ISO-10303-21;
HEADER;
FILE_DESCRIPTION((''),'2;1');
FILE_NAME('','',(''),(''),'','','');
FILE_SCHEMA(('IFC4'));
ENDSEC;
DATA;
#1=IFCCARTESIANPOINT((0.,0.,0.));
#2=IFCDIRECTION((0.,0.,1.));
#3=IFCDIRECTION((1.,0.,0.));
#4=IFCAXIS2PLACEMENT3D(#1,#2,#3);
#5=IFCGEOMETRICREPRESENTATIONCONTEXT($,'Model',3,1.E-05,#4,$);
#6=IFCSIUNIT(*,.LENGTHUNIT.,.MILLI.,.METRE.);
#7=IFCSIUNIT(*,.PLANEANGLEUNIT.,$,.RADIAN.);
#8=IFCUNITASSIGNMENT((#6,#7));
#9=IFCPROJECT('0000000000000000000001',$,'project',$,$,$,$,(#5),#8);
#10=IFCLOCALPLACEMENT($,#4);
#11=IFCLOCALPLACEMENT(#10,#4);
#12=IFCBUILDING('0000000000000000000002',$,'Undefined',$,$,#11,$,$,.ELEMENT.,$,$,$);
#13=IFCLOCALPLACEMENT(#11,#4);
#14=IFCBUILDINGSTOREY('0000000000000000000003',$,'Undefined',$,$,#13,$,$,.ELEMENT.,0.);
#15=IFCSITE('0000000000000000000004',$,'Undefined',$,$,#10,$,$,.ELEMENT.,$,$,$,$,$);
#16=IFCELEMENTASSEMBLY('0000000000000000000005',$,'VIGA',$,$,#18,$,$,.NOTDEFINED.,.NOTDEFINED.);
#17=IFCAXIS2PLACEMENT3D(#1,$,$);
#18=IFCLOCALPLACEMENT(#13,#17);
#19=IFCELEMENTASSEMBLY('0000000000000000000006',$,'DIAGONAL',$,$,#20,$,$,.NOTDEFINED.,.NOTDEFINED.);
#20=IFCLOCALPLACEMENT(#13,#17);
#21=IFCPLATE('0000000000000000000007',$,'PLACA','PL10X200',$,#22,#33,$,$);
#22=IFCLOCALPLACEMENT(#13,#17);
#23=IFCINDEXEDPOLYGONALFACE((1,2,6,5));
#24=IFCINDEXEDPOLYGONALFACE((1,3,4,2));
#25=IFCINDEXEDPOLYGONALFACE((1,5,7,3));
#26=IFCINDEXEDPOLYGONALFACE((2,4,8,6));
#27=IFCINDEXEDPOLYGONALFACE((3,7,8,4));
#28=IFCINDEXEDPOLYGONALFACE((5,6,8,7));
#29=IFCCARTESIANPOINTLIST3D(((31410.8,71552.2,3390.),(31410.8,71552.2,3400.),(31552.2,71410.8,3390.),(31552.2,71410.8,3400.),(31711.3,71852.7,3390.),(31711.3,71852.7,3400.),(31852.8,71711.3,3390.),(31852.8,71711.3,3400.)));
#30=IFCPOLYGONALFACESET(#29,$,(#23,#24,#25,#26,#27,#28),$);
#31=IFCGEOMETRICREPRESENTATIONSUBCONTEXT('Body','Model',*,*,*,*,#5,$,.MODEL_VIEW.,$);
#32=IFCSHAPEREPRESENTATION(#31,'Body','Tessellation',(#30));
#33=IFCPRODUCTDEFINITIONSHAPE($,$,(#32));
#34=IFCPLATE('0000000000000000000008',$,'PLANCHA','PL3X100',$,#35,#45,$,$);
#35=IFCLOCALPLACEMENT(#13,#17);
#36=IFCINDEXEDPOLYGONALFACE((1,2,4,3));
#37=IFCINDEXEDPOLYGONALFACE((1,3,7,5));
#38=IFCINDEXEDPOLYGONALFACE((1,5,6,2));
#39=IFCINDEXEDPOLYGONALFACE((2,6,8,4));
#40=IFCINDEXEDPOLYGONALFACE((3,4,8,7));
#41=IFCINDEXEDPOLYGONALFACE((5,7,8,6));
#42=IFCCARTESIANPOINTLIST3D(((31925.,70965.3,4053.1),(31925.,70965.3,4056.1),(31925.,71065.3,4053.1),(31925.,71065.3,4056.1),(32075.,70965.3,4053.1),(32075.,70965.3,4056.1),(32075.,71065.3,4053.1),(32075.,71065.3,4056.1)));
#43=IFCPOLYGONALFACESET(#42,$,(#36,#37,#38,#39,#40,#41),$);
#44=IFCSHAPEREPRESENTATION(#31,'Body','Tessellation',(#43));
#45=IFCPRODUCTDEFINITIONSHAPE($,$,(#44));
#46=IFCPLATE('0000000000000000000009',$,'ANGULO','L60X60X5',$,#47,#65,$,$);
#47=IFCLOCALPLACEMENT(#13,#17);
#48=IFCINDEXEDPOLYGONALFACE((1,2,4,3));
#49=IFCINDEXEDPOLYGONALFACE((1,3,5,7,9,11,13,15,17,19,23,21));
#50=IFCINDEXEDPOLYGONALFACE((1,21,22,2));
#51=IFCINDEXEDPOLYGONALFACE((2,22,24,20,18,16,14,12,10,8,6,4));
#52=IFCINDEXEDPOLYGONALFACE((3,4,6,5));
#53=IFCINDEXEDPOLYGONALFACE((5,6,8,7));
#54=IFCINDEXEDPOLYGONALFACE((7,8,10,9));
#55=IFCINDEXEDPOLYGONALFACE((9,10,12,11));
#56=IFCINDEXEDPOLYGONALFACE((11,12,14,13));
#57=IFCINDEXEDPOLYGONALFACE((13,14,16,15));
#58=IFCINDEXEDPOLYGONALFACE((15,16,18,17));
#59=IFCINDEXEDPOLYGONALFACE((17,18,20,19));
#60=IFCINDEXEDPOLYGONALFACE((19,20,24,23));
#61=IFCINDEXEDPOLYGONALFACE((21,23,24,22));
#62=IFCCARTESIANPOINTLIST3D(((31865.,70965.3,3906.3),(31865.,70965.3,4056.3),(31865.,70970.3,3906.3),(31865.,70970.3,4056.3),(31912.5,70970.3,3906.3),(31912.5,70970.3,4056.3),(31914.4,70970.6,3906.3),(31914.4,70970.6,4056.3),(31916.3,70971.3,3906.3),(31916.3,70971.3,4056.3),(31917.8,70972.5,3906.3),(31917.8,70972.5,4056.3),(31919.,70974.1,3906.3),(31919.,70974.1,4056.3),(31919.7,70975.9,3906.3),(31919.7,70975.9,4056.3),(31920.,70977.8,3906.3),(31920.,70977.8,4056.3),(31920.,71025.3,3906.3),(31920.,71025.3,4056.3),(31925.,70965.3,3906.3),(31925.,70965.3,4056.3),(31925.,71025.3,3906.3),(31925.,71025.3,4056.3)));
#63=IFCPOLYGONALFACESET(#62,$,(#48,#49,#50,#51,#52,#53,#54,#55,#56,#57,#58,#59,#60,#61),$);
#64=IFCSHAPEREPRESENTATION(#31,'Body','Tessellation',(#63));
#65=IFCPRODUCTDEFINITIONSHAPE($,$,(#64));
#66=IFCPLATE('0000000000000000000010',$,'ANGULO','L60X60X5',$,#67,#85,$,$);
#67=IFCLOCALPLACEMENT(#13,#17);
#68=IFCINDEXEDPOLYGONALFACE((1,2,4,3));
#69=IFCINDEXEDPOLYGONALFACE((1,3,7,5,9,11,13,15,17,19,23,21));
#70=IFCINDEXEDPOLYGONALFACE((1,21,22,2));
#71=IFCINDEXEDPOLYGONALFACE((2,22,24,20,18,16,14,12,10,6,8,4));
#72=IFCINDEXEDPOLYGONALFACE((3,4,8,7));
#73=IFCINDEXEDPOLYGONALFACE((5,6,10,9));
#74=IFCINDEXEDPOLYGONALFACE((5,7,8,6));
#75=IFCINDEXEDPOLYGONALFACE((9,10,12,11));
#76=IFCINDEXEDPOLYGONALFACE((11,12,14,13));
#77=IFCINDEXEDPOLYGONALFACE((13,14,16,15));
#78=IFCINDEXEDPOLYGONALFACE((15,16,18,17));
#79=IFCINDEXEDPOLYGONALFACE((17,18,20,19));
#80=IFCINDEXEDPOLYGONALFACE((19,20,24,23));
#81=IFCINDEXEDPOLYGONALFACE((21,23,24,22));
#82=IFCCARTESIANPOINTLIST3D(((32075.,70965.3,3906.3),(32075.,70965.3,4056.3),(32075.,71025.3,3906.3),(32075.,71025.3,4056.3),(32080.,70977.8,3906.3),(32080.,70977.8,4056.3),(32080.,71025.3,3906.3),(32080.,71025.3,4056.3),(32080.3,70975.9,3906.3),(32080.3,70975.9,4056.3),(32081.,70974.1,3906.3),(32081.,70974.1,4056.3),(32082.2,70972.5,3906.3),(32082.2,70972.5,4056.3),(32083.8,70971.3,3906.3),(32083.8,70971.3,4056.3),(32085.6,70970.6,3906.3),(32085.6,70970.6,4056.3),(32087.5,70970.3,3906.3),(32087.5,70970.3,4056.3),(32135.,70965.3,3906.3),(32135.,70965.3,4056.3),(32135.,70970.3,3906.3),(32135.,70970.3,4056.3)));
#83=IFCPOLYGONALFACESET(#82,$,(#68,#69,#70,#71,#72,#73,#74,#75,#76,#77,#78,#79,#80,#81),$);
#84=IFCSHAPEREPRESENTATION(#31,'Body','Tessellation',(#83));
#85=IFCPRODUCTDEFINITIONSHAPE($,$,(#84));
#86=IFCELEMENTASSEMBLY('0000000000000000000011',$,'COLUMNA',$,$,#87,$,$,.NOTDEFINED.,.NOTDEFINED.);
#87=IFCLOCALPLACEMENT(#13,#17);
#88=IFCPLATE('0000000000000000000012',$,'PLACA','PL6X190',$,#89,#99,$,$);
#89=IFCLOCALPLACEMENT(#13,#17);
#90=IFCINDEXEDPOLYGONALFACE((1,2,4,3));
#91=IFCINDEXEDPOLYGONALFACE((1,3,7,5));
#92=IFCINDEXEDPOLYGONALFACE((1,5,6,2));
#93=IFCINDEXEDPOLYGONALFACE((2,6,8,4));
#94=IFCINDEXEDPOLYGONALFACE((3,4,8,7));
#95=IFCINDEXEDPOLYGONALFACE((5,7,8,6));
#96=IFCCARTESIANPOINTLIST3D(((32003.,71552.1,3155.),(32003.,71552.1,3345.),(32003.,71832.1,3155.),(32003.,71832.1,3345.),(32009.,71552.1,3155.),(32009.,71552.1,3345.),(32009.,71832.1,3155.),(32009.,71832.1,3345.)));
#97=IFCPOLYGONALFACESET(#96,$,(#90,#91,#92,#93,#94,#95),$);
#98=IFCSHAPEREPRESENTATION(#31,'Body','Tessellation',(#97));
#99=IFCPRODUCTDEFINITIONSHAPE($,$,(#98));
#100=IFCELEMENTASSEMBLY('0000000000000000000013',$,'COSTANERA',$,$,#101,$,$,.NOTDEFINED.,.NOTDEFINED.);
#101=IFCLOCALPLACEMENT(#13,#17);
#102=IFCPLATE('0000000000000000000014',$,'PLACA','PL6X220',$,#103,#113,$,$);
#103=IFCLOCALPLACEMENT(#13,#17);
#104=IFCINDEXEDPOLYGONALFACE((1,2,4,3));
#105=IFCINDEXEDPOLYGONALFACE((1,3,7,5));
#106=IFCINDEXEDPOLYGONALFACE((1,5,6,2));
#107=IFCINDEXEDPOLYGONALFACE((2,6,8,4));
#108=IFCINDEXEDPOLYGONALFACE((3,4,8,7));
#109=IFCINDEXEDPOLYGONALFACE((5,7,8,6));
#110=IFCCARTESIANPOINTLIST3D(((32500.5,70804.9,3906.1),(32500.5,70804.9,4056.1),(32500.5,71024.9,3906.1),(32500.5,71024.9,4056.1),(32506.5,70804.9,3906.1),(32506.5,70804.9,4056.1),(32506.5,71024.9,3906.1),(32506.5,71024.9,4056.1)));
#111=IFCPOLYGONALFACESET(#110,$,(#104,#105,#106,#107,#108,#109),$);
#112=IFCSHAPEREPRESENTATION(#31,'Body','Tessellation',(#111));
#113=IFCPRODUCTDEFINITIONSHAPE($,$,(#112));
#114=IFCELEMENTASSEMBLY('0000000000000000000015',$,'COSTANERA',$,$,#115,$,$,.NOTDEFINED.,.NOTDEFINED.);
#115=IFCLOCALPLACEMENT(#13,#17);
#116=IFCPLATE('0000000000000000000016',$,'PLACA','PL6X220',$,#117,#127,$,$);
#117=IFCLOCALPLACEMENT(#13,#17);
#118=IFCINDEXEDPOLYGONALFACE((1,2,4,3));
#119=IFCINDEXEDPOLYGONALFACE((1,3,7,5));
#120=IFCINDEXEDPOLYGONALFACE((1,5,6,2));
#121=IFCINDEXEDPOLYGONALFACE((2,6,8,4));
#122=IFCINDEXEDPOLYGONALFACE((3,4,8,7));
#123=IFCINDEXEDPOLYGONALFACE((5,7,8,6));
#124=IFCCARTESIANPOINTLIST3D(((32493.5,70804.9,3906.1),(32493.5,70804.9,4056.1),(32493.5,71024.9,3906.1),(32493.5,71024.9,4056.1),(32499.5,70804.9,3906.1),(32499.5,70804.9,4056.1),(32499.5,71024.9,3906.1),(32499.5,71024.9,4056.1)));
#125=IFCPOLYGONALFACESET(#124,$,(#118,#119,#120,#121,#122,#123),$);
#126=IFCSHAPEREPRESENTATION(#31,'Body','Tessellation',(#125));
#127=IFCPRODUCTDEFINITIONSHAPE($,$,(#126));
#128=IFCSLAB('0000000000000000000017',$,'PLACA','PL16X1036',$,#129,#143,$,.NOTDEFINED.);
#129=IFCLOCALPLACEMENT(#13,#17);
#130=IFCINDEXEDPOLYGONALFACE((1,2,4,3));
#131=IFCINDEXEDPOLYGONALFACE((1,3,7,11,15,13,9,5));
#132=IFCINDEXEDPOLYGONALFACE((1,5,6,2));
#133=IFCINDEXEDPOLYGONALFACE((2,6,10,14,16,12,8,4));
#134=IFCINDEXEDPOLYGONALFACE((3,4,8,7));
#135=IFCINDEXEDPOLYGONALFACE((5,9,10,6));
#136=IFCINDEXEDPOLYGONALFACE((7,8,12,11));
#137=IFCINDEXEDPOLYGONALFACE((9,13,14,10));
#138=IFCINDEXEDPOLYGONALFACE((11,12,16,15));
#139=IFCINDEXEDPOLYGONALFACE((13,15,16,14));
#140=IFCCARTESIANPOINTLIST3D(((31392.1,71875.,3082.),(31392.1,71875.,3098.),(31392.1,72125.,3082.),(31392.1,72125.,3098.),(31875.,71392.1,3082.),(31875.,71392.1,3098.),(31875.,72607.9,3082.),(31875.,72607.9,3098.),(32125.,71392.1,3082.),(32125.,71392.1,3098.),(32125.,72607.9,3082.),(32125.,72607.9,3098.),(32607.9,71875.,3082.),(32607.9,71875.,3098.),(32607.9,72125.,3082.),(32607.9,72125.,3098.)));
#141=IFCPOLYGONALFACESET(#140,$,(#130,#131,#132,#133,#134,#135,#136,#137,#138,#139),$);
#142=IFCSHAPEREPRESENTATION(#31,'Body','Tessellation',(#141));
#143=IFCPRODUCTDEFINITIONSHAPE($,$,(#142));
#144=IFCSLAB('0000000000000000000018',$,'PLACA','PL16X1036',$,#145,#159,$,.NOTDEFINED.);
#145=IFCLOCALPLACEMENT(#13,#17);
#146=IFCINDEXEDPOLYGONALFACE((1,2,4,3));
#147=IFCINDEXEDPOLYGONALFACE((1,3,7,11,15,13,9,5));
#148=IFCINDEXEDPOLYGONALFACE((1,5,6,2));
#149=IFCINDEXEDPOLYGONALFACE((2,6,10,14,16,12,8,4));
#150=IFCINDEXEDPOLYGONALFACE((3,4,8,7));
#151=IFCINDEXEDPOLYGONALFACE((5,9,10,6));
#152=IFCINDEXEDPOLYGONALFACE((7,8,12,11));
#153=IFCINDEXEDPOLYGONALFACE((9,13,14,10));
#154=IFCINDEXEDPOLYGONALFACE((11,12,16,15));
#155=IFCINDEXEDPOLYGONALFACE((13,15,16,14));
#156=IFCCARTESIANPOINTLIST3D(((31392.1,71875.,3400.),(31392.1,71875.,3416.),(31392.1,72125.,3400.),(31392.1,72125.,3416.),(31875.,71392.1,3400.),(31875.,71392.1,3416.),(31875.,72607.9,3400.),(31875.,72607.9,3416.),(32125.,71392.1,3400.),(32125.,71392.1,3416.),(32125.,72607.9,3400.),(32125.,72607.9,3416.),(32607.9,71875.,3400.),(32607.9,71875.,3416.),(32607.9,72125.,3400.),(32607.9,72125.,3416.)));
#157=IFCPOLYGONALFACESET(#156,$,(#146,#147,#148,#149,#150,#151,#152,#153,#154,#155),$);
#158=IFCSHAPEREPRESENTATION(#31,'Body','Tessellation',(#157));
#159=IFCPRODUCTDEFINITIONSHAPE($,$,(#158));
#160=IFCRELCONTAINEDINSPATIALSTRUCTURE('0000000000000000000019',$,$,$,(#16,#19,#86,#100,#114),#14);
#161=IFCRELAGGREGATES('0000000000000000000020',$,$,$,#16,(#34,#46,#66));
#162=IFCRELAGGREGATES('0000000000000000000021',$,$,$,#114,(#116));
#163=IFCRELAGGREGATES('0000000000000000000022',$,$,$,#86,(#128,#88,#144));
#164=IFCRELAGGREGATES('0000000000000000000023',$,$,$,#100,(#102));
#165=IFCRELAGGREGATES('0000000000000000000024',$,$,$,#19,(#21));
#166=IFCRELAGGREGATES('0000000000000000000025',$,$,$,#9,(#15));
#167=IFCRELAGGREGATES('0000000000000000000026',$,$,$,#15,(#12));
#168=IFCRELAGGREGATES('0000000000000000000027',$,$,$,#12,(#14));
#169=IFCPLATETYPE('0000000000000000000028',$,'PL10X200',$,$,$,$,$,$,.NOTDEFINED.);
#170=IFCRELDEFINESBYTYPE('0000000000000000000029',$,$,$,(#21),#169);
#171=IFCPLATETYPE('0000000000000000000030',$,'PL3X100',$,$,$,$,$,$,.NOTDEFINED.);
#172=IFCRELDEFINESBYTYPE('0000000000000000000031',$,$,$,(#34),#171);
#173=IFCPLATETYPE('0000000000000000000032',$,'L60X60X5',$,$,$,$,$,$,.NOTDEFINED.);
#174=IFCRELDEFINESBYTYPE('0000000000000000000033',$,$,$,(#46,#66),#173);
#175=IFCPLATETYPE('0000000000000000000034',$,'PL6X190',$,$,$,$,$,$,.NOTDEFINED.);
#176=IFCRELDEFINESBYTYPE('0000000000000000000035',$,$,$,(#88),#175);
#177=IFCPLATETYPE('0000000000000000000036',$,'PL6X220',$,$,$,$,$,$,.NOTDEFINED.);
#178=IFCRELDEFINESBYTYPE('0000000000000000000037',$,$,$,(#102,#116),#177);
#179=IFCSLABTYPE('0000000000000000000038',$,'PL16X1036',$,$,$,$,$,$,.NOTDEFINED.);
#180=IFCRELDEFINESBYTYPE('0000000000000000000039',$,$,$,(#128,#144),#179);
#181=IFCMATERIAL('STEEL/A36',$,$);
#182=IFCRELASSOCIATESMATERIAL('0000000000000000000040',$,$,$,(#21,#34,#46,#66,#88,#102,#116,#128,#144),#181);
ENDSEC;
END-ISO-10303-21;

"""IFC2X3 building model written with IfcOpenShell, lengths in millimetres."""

from ifc_helpers import new_model, si_unit, frame, origin_with_axes, origin_2d_with_axis, place, context, subcontext, project, spatial, polyline, l_section, outline, extrude, material, type_object, element, aggregate, save


model = new_model("IFC2X3")

# Units and contexts
model_context = context("Model", 3, precision=1e-05, world=origin_with_axes())
body_context = subcontext(model_context, "Body", "Model", "MODEL_VIEW")
ifc_project = project(units=[si_unit("LENGTHUNIT", "METRE", prefix="MILLI"), si_unit("PLANEANGLEUNIT", "RADIAN")], contexts=[model_context])

# Site, building, storey
site_placement = place(None, origin_with_axes())
site = spatial("IfcSite", under=ifc_project, at=site_placement, Name="Undefined", CompositionType="ELEMENT")
building_placement = place(site_placement, origin_with_axes())
building = spatial("IfcBuilding", under=site, at=building_placement, Name="Undefined", CompositionType="ELEMENT")
storey_placement = place(building_placement, origin_with_axes())
storey = spatial("IfcBuildingStorey", under=building, at=storey_placement, Name="Undefined", CompositionType="ELEMENT", Elevation=0.0)

# Element assembly
assembly_1_placement = place(storey_placement, origin_with_axes())
assembly_1 = element("IfcElementAssembly", 1, at=assembly_1_placement, inside=storey, Name="VIGA", AssemblyPlace="NOTDEFINED", PredefinedType="NOTDEFINED")
ifc_material_1 = material(Name="STEEL/A36")

# Element assembly
assembly_2_placement = place(storey_placement, origin_with_axes())
assembly_2 = element("IfcElementAssembly", 2, at=assembly_2_placement, inside=storey, Name="DIAGONAL", AssemblyPlace="NOTDEFINED", PredefinedType="NOTDEFINED")

# Plates
plate_type_1 = type_object("IfcPlateType", Name="PL10X200", PredefinedType="NOTDEFINED")
plate_1_placement = place(assembly_2_placement, frame((31782.0, 71782.0, 3395.0), z_axis=(0.0, 0.0, -1.0), x_axis=(-0.707107, -0.707107, 0.0)))
plate_1 = element("IfcPlate", 3, at=plate_1_placement, type_object=plate_type_1, material=ifc_material_1, Name="PLACA", Description="PL10X200", context=body_context, shape_type="SweptSolid", body=[
    extrude(outline(polyline([(0.0, -100.0), (0.0, 100.0), (425.0, 100.0), (425.0, -100.0), (0.0, -100.0)])), frame((0.0, 0.0, -5.0), z_axis=(0.0, 0.0, 1.0), x_axis=(1.0, 0.0, 0.0)), (0.0, 0.0, 1.0), 10.0),
])
plate_type_2 = type_object("IfcPlateType", Name="PL3X100", PredefinedType="NOTDEFINED")
plate_2_placement = place(assembly_1_placement, frame((32075.0, 71065.3, 4054.6), z_axis=(0.0, 0.0, -1.0), x_axis=(0.0, -1.0, 0.0)))
plate_2 = element("IfcPlate", 4, at=plate_2_placement, type_object=plate_type_2, material=ifc_material_1, Name="PLANCHA", Description="PL3X100", context=body_context, shape_type="SweptSolid", body=[
    extrude(outline(polyline([(0.0, 0.0), (100.0, 0.0), (100.0, 150.0), (0.0, 150.0), (0.0, 0.0)])), frame((0.0, 0.0, -1.5), z_axis=(0.0, 0.0, 1.0), x_axis=(1.0, 0.0, 0.0)), (0.0, 0.0, 1.0), 3.0),
])
plate_type_3 = type_object("IfcPlateType", Name="L60X60X5", PredefinedType="NOTDEFINED")
plate_3_placement = place(assembly_1_placement, frame((31895.0, 70995.3, 3906.3), z_axis=(0.0, 1.0, 0.0), x_axis=(0.0, 0.0, 1.0)))
plate_3 = element("IfcPlate", 5, at=plate_3_placement, type_object=plate_type_3, material=ifc_material_1, Name="ANGULO", Description="L60X60X5", context=body_context, shape_type="SweptSolid", body=[
    extrude(l_section(Depth=60.0, Width=60.0, Thickness=5.0, FilletRadius=7.5, at=origin_2d_with_axis()), frame((150.0, 0.0, 0.0), z_axis=(-1.0, 0.0, 0.0), x_axis=(0.0, -1.0, 0.0)), (0.0, 0.0, 1.0), 150.0),
])
plate_4_placement = place(assembly_1_placement, frame((32105.0, 70995.3, 4056.3), z_axis=(0.0, 1.0, 0.0), x_axis=(0.0, 0.0, -1.0)))
plate_4 = element("IfcPlate", 6, at=plate_4_placement, type_object=plate_type_3, material=ifc_material_1, Name="ANGULO", Description="L60X60X5", context=body_context, shape_type="SweptSolid", body=[
    extrude(l_section(Depth=60.0, Width=60.0, Thickness=5.0, FilletRadius=7.5, at=origin_2d_with_axis()), frame((150.0, 0.0, 0.0), z_axis=(-1.0, 0.0, 0.0), x_axis=(0.0, -1.0, 0.0)), (0.0, 0.0, 1.0), 150.0),
])
aggregate(assembly_1, [plate_2, plate_3, plate_4])

# Element assemblies, plates
assembly_3_placement = place(storey_placement, origin_with_axes())
assembly_3 = element("IfcElementAssembly", 7, at=assembly_3_placement, inside=storey, Name="COLUMNA", AssemblyPlace="NOTDEFINED", PredefinedType="NOTDEFINED")
plate_type_4 = type_object("IfcPlateType", Name="PL6X190", PredefinedType="NOTDEFINED")
plate_5_placement = place(assembly_3_placement, frame((32006.0, 71552.1, 3250.0), z_axis=(1.0, 0.0, 0.0), x_axis=(0.0, 1.0, 0.0)))
plate_5 = element("IfcPlate", 8, at=plate_5_placement, type_object=plate_type_4, material=ifc_material_1, Name="PLACA", Description="PL6X190", context=body_context, shape_type="SweptSolid", body=[
    extrude(outline(polyline([(0.0, -95.0), (0.0, 95.0), (280.0, 95.0), (280.0, -95.0), (0.0, -95.0)])), frame((0.0, 0.0, -3.0), z_axis=(0.0, 0.0, 1.0), x_axis=(1.0, 0.0, 0.0)), (0.0, 0.0, 1.0), 6.0),
])
assembly_4_placement = place(storey_placement, origin_with_axes())
assembly_4 = element("IfcElementAssembly", 9, at=assembly_4_placement, inside=storey, Name="COSTANERA", AssemblyPlace="NOTDEFINED", PredefinedType="NOTDEFINED")
plate_type_5 = type_object("IfcPlateType", Name="PL6X220", PredefinedType="NOTDEFINED")
plate_6_placement = place(assembly_4_placement, frame((32503.5, 70914.9, 3906.1), z_axis=(1.0, 0.0, 0.0), x_axis=(0.0, 0.0, 1.0)))
plate_6 = element("IfcPlate", 10, at=plate_6_placement, type_object=plate_type_5, material=ifc_material_1, Name="PLACA", Description="PL6X220", context=body_context, shape_type="SweptSolid", body=[
    extrude(outline(polyline([(0.0, -110.0), (0.0, 110.0), (150.0, 110.0), (150.0, -110.0), (0.0, -110.0)])), frame((0.0, 0.0, -3.0), z_axis=(0.0, 0.0, 1.0), x_axis=(1.0, 0.0, 0.0)), (0.0, 0.0, 1.0), 6.0),
])
assembly_5_placement = place(storey_placement, origin_with_axes())
assembly_5 = element("IfcElementAssembly", 11, at=assembly_5_placement, inside=storey, Name="COSTANERA", AssemblyPlace="NOTDEFINED", PredefinedType="NOTDEFINED")
plate_7_placement = place(assembly_5_placement, frame((32496.5, 70914.9, 3906.1), z_axis=(1.0, 0.0, 0.0), x_axis=(0.0, 0.0, 1.0)))
plate_7 = element("IfcPlate", 12, at=plate_7_placement, type_object=plate_type_5, material=ifc_material_1, Name="PLACA", Description="PL6X220", context=body_context, shape_type="SweptSolid", body=[
    extrude(outline(polyline([(0.0, -110.0), (0.0, 110.0), (150.0, 110.0), (150.0, -110.0), (0.0, -110.0)])), frame((0.0, 0.0, -3.0), z_axis=(0.0, 0.0, 1.0), x_axis=(1.0, 0.0, 0.0)), (0.0, 0.0, 1.0), 6.0),
])

# Slabs
slab_type = type_object("IfcSlabType", Name="PL16X1036", PredefinedType="NOTDEFINED")
slab_1_placement = place(assembly_3_placement, frame((32125.0, 71392.1, 3090.0), z_axis=(0.0, 0.0, 1.0), x_axis=(0.707107, 0.707107, 0.0)))
slab_1 = element("IfcSlab", 13, at=slab_1_placement, type_object=slab_type, material=ifc_material_1, Name="PLACA", Description="PL16X1036", PredefinedType="NOTDEFINED", context=body_context, shape_type="SweptSolid", body=[
    extrude(outline(polyline([(0.0, 0.0), (682.9, 0.0), (859.7, 176.8), (859.7, 859.7), (682.9, 1036.5), (0.0, 1036.5), (-176.8, 859.7), (-176.8, 176.8), (0.0, 0.0)])), frame((0.0, 0.0, -8.0), z_axis=(0.0, 0.0, 1.0), x_axis=(1.0, 0.0, 0.0)), (0.0, 0.0, 1.0), 16.0),
])
slab_2_placement = place(assembly_3_placement, frame((32125.0, 71392.1, 3408.0), z_axis=(0.0, 0.0, 1.0), x_axis=(0.707107, 0.707107, 0.0)))
slab_2 = element("IfcSlab", 14, at=slab_2_placement, type_object=slab_type, material=ifc_material_1, Name="PLACA", Description="PL16X1036", PredefinedType="NOTDEFINED", context=body_context, shape_type="SweptSolid", body=[
    extrude(outline(polyline([(0.0, 0.0), (682.9, 0.0), (859.7, 176.8), (859.7, 859.7), (682.9, 1036.5), (0.0, 1036.5), (-176.8, 859.7), (-176.8, 176.8), (0.0, 0.0)])), frame((0.0, 0.0, -8.0), z_axis=(0.0, 0.0, 1.0), x_axis=(1.0, 0.0, 0.0)), (0.0, 0.0, 1.0), 16.0),
])

aggregate(assembly_5, [plate_7])
aggregate(assembly_3, [slab_1, plate_5, slab_2])
aggregate(assembly_4, [plate_6])
aggregate(assembly_2, [plate_1])

save(model, "model.ifc")
